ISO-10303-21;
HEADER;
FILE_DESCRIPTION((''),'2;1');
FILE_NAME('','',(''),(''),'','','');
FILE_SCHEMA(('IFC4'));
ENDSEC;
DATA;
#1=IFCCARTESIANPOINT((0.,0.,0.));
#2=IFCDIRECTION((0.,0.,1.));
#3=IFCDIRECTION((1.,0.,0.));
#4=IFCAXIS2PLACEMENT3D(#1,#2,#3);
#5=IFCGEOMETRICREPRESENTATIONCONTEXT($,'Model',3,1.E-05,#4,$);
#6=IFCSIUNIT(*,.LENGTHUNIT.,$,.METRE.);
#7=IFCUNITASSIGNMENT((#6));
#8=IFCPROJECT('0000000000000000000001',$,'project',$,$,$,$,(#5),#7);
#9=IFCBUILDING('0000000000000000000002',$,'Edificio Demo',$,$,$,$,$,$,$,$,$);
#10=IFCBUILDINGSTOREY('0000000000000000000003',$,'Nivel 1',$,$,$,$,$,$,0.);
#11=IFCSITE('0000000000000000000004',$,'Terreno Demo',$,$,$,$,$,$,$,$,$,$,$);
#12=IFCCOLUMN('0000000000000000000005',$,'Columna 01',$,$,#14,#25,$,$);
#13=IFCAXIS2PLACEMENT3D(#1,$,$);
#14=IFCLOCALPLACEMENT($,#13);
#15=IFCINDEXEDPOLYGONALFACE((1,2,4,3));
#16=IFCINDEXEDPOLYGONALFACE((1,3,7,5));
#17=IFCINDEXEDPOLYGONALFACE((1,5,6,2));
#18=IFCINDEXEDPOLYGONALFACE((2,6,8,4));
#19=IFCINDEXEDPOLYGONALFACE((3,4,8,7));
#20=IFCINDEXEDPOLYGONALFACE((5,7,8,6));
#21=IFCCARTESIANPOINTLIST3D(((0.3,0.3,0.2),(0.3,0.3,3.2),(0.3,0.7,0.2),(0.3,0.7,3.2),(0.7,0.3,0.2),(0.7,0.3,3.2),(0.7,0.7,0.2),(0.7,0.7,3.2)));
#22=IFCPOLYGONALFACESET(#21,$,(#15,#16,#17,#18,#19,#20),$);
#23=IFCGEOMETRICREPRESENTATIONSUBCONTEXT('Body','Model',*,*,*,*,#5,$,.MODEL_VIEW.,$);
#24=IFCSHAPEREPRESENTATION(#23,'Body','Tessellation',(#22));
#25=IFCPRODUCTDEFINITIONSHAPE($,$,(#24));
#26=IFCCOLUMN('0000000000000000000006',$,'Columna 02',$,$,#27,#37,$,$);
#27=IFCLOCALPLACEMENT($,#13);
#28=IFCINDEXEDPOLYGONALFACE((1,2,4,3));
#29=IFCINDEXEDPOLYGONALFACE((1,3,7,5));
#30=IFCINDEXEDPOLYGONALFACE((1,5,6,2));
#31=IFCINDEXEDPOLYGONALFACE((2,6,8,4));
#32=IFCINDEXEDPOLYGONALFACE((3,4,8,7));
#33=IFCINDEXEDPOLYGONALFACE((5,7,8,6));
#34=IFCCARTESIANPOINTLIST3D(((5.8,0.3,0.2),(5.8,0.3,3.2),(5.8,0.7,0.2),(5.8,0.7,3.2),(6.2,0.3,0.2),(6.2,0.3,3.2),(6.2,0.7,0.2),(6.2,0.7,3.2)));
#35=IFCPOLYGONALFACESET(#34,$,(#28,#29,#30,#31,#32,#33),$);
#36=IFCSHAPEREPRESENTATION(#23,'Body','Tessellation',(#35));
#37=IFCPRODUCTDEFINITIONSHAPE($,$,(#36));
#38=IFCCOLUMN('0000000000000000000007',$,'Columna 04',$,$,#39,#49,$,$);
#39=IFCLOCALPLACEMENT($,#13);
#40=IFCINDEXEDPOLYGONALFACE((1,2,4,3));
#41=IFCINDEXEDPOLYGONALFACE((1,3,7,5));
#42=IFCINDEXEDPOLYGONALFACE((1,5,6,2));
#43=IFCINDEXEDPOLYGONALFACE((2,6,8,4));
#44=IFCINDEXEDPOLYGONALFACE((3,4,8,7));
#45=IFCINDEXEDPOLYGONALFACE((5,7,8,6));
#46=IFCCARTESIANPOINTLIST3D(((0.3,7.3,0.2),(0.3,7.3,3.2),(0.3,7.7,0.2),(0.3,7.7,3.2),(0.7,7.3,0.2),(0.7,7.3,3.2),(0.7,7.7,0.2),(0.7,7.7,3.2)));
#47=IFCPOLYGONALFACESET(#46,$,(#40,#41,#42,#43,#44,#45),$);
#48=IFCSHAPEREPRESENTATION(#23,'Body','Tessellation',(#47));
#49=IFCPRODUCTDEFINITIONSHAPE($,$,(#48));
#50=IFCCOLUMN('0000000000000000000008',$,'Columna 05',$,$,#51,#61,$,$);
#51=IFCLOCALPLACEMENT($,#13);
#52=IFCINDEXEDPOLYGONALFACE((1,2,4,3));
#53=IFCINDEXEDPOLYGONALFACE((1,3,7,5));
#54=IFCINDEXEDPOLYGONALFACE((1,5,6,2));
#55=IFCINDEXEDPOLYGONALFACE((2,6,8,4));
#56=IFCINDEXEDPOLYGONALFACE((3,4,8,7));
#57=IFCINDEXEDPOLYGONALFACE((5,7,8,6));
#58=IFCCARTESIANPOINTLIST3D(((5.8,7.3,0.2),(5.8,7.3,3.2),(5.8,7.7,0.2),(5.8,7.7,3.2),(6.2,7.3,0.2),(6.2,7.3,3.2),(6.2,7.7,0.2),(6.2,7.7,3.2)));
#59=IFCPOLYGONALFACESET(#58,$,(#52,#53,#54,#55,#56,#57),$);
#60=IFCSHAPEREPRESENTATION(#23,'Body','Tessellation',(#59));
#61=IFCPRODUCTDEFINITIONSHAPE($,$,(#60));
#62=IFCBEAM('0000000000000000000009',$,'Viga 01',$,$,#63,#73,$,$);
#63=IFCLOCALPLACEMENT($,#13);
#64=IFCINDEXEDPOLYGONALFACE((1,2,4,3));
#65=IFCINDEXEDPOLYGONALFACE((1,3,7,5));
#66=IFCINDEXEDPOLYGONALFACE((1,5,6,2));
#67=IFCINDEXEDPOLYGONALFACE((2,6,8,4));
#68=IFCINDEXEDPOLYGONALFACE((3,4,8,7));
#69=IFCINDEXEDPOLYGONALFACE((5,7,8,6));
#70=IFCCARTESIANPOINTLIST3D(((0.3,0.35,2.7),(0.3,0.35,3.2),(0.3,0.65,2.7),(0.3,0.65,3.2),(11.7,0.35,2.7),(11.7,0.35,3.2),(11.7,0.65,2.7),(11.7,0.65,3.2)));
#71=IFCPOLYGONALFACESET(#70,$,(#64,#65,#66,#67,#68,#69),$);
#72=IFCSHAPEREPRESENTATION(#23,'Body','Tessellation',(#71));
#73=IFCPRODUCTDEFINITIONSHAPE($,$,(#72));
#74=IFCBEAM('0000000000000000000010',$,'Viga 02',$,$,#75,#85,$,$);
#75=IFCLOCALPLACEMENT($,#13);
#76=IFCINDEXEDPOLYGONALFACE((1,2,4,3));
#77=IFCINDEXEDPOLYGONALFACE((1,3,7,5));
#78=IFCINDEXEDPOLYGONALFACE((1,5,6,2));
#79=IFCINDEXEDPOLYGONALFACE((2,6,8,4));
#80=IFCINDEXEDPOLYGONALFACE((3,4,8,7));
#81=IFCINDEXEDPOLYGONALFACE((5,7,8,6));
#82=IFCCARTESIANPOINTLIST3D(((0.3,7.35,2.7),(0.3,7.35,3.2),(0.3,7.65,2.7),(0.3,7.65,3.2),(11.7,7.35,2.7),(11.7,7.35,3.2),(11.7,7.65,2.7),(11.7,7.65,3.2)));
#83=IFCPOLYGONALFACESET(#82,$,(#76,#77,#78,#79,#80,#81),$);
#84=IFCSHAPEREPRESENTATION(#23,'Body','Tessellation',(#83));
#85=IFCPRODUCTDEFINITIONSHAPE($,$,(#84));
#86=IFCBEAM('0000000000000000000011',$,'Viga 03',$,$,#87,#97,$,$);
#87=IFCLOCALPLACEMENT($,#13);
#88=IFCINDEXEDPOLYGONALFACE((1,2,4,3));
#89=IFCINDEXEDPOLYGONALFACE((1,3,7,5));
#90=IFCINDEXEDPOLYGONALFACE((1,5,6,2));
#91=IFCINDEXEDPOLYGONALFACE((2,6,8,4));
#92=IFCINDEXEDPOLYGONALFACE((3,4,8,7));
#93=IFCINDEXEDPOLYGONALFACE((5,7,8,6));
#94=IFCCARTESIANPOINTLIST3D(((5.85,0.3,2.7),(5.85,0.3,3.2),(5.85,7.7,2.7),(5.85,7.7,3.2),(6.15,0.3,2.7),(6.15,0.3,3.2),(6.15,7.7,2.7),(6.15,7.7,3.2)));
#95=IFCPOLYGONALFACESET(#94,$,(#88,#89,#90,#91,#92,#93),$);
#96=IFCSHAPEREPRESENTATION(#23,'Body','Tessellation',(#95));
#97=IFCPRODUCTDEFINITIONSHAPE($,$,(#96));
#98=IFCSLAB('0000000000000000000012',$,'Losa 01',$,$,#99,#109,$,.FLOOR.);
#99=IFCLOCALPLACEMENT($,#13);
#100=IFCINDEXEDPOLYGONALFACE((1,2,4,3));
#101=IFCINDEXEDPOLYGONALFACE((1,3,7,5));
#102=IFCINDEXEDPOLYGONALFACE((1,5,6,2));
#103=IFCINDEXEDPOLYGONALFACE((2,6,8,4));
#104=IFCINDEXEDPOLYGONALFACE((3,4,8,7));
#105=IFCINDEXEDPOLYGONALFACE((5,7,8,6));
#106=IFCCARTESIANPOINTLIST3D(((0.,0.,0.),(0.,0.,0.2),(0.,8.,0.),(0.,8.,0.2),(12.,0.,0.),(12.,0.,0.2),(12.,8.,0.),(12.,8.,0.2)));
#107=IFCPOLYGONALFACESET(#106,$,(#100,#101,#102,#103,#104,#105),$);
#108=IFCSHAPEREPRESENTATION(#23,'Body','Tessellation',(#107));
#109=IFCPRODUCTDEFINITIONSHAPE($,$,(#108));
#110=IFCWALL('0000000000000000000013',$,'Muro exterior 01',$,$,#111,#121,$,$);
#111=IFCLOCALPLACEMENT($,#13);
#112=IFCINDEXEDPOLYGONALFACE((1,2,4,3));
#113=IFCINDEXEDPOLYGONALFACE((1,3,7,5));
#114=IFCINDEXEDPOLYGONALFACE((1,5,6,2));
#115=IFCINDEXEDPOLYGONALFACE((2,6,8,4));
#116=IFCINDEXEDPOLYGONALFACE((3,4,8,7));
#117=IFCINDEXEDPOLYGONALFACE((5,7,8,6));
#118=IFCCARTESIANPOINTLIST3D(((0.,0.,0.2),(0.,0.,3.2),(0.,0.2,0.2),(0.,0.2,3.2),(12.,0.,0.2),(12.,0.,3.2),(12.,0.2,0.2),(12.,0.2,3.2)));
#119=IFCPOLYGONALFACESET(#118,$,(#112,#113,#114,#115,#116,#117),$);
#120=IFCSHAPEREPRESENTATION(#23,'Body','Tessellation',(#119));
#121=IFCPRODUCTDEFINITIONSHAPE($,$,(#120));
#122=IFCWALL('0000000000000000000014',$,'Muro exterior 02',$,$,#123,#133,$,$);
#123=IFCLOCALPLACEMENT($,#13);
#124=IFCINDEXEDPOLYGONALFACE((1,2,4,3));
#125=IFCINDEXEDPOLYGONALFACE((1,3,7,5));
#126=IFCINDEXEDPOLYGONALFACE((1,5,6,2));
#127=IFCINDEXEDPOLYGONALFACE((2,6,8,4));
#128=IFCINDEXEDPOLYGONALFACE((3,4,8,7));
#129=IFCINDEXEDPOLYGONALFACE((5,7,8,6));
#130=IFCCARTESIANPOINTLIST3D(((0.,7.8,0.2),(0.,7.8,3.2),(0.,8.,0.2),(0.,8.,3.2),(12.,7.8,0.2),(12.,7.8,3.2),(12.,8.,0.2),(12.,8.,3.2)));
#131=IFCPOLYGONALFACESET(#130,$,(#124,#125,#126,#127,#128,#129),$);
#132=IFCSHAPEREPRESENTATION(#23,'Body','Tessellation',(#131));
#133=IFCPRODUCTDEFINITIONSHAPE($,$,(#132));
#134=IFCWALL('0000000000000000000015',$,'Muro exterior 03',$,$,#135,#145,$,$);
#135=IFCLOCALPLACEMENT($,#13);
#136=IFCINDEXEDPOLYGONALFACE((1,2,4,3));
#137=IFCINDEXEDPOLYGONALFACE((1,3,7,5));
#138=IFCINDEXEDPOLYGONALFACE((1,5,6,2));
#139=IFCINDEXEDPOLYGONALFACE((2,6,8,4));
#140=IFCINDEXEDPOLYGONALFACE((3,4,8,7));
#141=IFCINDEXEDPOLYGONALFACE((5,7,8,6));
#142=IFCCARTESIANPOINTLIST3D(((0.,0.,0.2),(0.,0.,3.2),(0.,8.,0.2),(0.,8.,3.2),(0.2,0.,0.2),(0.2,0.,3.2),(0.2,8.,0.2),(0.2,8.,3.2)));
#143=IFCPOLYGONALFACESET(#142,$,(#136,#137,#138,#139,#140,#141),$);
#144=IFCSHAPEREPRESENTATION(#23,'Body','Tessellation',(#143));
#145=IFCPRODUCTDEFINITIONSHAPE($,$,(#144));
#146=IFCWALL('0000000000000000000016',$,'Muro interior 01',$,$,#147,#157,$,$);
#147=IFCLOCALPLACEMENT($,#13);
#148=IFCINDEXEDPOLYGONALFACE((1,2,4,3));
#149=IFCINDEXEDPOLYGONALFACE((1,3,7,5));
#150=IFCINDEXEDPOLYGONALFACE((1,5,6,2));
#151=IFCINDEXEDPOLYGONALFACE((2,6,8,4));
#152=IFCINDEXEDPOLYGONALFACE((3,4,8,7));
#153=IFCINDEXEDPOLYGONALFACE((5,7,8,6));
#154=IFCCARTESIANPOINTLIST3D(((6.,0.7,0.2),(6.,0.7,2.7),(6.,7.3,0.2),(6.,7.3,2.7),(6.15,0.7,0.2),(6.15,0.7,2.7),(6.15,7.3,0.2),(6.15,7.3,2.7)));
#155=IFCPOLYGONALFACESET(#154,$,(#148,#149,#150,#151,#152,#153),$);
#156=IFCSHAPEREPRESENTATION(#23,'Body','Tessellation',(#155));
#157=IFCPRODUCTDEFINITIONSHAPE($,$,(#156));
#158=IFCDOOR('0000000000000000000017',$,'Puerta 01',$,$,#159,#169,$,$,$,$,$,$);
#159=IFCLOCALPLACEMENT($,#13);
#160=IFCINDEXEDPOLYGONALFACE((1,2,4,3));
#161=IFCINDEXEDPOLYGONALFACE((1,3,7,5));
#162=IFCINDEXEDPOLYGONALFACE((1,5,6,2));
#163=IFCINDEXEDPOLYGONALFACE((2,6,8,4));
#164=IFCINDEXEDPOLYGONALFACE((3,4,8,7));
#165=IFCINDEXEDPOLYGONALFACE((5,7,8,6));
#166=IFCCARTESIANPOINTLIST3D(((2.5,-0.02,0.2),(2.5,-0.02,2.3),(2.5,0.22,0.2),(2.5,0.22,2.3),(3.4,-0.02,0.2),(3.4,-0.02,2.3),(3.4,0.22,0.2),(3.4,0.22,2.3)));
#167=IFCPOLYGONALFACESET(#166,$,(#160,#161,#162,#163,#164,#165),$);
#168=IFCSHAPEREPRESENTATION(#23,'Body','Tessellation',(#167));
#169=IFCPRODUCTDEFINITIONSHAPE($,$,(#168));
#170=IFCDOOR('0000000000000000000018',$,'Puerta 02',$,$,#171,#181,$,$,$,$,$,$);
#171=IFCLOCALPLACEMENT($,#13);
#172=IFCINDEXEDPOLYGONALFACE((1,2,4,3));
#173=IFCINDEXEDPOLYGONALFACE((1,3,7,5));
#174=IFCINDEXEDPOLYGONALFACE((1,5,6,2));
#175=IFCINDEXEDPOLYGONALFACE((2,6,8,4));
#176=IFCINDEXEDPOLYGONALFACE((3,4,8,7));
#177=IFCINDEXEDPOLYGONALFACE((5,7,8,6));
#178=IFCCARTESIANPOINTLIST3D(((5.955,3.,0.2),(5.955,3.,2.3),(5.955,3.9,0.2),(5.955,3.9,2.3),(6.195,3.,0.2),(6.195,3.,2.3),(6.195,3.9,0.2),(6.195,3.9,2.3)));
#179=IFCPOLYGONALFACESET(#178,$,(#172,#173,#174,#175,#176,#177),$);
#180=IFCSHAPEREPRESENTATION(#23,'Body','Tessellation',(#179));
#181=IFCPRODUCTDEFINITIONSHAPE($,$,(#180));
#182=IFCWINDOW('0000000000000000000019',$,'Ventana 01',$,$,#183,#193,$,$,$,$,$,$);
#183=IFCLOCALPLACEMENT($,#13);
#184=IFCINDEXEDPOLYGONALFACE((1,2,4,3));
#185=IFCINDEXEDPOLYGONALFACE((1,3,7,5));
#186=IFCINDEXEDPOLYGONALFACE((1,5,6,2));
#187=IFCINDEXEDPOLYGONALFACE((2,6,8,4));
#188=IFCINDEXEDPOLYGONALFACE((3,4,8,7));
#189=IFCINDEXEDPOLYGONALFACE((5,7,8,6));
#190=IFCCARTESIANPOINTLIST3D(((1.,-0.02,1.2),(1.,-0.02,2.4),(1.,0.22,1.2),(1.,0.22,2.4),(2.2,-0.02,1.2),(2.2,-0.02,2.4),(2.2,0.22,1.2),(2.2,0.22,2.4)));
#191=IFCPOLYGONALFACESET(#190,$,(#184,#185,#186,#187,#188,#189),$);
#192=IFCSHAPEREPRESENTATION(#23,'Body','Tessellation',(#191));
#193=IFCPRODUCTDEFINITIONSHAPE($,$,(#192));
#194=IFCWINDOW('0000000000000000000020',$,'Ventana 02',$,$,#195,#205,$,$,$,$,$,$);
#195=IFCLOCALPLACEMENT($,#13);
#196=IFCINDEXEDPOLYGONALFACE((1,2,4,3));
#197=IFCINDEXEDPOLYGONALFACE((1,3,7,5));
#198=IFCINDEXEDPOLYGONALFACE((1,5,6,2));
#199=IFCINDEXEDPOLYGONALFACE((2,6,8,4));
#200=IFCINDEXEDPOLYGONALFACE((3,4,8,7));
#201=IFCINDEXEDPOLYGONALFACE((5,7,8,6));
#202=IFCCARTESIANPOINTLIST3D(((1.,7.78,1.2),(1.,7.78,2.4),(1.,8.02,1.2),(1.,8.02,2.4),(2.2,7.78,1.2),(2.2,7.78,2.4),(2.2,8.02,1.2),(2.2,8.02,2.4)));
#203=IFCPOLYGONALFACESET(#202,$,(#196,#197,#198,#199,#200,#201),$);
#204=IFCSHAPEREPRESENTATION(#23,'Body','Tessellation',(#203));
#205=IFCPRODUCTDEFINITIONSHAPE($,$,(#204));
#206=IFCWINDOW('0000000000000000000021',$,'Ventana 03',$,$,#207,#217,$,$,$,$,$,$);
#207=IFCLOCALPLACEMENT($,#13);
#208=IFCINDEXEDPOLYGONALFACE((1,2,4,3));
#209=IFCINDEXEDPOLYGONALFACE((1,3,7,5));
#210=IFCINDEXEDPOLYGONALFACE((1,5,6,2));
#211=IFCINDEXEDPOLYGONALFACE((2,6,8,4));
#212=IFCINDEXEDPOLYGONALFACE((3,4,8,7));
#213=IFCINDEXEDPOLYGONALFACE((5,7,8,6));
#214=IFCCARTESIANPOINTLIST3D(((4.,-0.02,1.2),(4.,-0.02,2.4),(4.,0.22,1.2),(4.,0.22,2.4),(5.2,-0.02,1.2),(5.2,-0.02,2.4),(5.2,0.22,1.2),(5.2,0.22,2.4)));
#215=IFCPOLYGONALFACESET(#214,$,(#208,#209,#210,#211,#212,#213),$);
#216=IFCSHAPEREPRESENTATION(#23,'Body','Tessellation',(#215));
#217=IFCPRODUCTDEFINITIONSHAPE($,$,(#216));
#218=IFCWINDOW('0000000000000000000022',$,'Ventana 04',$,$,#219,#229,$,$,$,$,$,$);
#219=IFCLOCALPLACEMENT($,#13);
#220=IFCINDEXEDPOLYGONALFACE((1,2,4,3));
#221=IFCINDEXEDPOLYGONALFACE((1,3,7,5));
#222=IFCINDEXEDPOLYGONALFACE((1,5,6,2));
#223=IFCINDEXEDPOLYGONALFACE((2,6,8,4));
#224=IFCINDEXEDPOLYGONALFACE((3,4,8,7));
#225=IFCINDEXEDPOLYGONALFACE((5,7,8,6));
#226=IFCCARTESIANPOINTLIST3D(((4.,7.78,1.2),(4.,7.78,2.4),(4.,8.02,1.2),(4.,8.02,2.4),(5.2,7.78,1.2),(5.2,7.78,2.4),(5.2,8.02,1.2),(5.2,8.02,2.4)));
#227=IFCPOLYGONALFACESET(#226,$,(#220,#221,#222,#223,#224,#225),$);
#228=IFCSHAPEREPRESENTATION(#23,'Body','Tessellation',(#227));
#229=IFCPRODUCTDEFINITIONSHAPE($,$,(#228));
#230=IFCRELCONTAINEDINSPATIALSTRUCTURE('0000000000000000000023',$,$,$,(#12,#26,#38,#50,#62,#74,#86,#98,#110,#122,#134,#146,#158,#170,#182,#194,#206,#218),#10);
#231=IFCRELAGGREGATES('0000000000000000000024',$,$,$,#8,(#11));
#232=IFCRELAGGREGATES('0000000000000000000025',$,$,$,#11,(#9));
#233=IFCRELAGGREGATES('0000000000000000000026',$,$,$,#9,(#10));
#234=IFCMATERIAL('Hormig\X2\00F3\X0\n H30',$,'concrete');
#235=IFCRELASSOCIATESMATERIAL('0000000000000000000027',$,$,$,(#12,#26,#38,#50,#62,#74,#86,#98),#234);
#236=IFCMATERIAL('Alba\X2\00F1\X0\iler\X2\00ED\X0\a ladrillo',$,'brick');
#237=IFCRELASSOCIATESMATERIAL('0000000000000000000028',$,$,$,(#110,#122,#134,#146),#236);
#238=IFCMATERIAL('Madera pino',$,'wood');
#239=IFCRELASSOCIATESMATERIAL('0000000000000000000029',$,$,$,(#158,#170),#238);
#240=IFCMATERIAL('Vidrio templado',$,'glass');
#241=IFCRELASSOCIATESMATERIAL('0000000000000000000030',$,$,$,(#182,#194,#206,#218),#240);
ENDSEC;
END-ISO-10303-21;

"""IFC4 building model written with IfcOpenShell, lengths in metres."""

from ifc_helpers import new_model, si_unit, frame, frame_2d, origin_with_axes, place, context, subcontext, project, spatial, rectangle, extrude, material, element, save


model = new_model("IFC4")

# Units and contexts
model_context = context("Model", 3, precision=1e-05, world=origin_with_axes())
body_context = subcontext(model_context, "Body", "Model", "MODEL_VIEW")
ifc_project = project(units=[si_unit("LENGTHUNIT", "METRE")], contexts=[model_context])

# Site, building, storey
site = spatial("IfcSite", under=ifc_project, Name="Terreno Demo")
building = spatial("IfcBuilding", under=site, Name="Edificio Demo")
storey = spatial("IfcBuildingStorey", under=building, Name="Nivel 1", Elevation=0.0)

# Columns
ifc_material_1 = material(Name="Hormigón H30", Category="concrete")
for number, where, z_axis, x_axis, name in (
    (1, (0.3, 0.3, 0.2), (0.0, 0.0, 1.0), (1.0, 0.0, 0.0), "Columna 01"),
    (2, (5.8, 0.3, 0.2), (0.0, 0.0, 1.0), (1.0, 0.0, 0.0), "Columna 02"),
    (3, (0.3, 7.3, 0.2), (0.0, 0.0, 1.0), (1.0, 0.0, 0.0), "Columna 04"),
    (4, (5.8, 7.3, 0.2), (0.0, 0.0, 1.0), (1.0, 0.0, 0.0), "Columna 05"),
):
    element("IfcColumn", number, at=place(None, frame(where, z_axis=z_axis, x_axis=x_axis)), inside=storey, material=ifc_material_1, Name=name, context=body_context, shape_type="SweptSolid", body=[
        extrude(rectangle(XDim=0.4, YDim=0.4, at=frame_2d((0.2, 0.2))), origin_with_axes(), (0.0, 0.0, 1.0), 3.0),
    ])

# Beams
for number, where, z_axis, x_axis, name in (
    (5, (0.3, 0.35, 2.7), (0.0, 0.0, 1.0), (1.0, 0.0, 0.0), "Viga 01"),
    (6, (0.3, 7.35, 2.7), (0.0, 0.0, 1.0), (1.0, 0.0, 0.0), "Viga 02"),
):
    element("IfcBeam", number, at=place(None, frame(where, z_axis=z_axis, x_axis=x_axis)), inside=storey, material=ifc_material_1, Name=name, context=body_context, shape_type="SweptSolid", body=[
        extrude(rectangle(XDim=11.4, YDim=0.3, at=frame_2d((5.7, 0.15))), origin_with_axes(), (0.0, 0.0, 1.0), 0.5),
    ])
beam_placement = place(None, frame((5.85, 0.3, 2.7), z_axis=(0.0, 0.0, 1.0), x_axis=(1.0, 0.0, 0.0)))
element("IfcBeam", 7, at=beam_placement, inside=storey, material=ifc_material_1, Name="Viga 03", context=body_context, shape_type="SweptSolid", body=[
    extrude(rectangle(XDim=0.3, YDim=7.4, at=frame_2d((0.15, 3.7))), origin_with_axes(), (0.0, 0.0, 1.0), 0.5),
])

# Slab
slab_placement = place(None, origin_with_axes())
element("IfcSlab", 8, at=slab_placement, inside=storey, material=ifc_material_1, Name="Losa 01", PredefinedType="FLOOR", context=body_context, shape_type="SweptSolid", body=[
    extrude(rectangle(XDim=12.0, YDim=8.0, at=frame_2d((6.0, 4.0))), origin_with_axes(), (0.0, 0.0, 1.0), 0.2),
])

# Walls
ifc_material_2 = material(Name="Albañilería ladrillo", Category="brick")
for number, where, z_axis, x_axis, name in (
    (9, (0.0, 0.0, 0.2), (0.0, 0.0, 1.0), (1.0, 0.0, 0.0), "Muro exterior 01"),
    (10, (0.0, 7.8, 0.2), (0.0, 0.0, 1.0), (1.0, 0.0, 0.0), "Muro exterior 02"),
):
    element("IfcWall", number, at=place(None, frame(where, z_axis=z_axis, x_axis=x_axis)), inside=storey, material=ifc_material_2, Name=name, context=body_context, shape_type="SweptSolid", body=[
        extrude(rectangle(XDim=12.0, YDim=0.2, at=frame_2d((6.0, 0.1))), origin_with_axes(), (0.0, 0.0, 1.0), 3.0),
    ])
wall_1_placement = place(None, frame((0.0, 0.0, 0.2), z_axis=(0.0, 0.0, 1.0), x_axis=(1.0, 0.0, 0.0)))
element("IfcWall", 11, at=wall_1_placement, inside=storey, material=ifc_material_2, Name="Muro exterior 03", context=body_context, shape_type="SweptSolid", body=[
    extrude(rectangle(XDim=0.2, YDim=8.0, at=frame_2d((0.1, 4.0))), origin_with_axes(), (0.0, 0.0, 1.0), 3.0),
])
wall_2_placement = place(None, frame((6.0, 0.7, 0.2), z_axis=(0.0, 0.0, 1.0), x_axis=(1.0, 0.0, 0.0)))
element("IfcWall", 12, at=wall_2_placement, inside=storey, material=ifc_material_2, Name="Muro interior 01", context=body_context, shape_type="SweptSolid", body=[
    extrude(rectangle(XDim=0.15, YDim=6.6, at=frame_2d((0.075, 3.3))), origin_with_axes(), (0.0, 0.0, 1.0), 2.5),
])

# Doors
ifc_material_3 = material(Name="Madera pino", Category="wood")
for number, where, z_axis, x_axis, name in (
    (13, (2.5, -0.02, 0.2), (0.0, 0.0, 1.0), (1.0, 0.0, 0.0), "Puerta 01"),
    (14, (6.195, 3.0, 0.2), (0.0, 0.0, 1.0), (0.0, 1.0, 0.0), "Puerta 02"),
):
    element("IfcDoor", number, at=place(None, frame(where, z_axis=z_axis, x_axis=x_axis)), inside=storey, material=ifc_material_3, Name=name, context=body_context, shape_type="SweptSolid", body=[
        extrude(rectangle(XDim=0.9, YDim=0.24, at=frame_2d((0.45, 0.12))), origin_with_axes(), (0.0, 0.0, 1.0), 2.1),
    ])

# Windows
ifc_material_4 = material(Name="Vidrio templado", Category="glass")
for number, where, z_axis, x_axis, name in (
    (15, (1.0, -0.02, 1.2), (0.0, 0.0, 1.0), (1.0, 0.0, 0.0), "Ventana 01"),
    (16, (1.0, 7.78, 1.2), (0.0, 0.0, 1.0), (1.0, 0.0, 0.0), "Ventana 02"),
    (17, (4.0, -0.02, 1.2), (0.0, 0.0, 1.0), (1.0, 0.0, 0.0), "Ventana 03"),
    (18, (4.0, 7.78, 1.2), (0.0, 0.0, 1.0), (1.0, 0.0, 0.0), "Ventana 04"),
):
    element("IfcWindow", number, at=place(None, frame(where, z_axis=z_axis, x_axis=x_axis)), inside=storey, material=ifc_material_4, Name=name, context=body_context, shape_type="SweptSolid", body=[
        extrude(rectangle(XDim=1.2, YDim=0.24, at=frame_2d((0.6, 0.12))), origin_with_axes(), (0.0, 0.0, 1.0), 1.2),
    ])

save(model, "model.ifc")
